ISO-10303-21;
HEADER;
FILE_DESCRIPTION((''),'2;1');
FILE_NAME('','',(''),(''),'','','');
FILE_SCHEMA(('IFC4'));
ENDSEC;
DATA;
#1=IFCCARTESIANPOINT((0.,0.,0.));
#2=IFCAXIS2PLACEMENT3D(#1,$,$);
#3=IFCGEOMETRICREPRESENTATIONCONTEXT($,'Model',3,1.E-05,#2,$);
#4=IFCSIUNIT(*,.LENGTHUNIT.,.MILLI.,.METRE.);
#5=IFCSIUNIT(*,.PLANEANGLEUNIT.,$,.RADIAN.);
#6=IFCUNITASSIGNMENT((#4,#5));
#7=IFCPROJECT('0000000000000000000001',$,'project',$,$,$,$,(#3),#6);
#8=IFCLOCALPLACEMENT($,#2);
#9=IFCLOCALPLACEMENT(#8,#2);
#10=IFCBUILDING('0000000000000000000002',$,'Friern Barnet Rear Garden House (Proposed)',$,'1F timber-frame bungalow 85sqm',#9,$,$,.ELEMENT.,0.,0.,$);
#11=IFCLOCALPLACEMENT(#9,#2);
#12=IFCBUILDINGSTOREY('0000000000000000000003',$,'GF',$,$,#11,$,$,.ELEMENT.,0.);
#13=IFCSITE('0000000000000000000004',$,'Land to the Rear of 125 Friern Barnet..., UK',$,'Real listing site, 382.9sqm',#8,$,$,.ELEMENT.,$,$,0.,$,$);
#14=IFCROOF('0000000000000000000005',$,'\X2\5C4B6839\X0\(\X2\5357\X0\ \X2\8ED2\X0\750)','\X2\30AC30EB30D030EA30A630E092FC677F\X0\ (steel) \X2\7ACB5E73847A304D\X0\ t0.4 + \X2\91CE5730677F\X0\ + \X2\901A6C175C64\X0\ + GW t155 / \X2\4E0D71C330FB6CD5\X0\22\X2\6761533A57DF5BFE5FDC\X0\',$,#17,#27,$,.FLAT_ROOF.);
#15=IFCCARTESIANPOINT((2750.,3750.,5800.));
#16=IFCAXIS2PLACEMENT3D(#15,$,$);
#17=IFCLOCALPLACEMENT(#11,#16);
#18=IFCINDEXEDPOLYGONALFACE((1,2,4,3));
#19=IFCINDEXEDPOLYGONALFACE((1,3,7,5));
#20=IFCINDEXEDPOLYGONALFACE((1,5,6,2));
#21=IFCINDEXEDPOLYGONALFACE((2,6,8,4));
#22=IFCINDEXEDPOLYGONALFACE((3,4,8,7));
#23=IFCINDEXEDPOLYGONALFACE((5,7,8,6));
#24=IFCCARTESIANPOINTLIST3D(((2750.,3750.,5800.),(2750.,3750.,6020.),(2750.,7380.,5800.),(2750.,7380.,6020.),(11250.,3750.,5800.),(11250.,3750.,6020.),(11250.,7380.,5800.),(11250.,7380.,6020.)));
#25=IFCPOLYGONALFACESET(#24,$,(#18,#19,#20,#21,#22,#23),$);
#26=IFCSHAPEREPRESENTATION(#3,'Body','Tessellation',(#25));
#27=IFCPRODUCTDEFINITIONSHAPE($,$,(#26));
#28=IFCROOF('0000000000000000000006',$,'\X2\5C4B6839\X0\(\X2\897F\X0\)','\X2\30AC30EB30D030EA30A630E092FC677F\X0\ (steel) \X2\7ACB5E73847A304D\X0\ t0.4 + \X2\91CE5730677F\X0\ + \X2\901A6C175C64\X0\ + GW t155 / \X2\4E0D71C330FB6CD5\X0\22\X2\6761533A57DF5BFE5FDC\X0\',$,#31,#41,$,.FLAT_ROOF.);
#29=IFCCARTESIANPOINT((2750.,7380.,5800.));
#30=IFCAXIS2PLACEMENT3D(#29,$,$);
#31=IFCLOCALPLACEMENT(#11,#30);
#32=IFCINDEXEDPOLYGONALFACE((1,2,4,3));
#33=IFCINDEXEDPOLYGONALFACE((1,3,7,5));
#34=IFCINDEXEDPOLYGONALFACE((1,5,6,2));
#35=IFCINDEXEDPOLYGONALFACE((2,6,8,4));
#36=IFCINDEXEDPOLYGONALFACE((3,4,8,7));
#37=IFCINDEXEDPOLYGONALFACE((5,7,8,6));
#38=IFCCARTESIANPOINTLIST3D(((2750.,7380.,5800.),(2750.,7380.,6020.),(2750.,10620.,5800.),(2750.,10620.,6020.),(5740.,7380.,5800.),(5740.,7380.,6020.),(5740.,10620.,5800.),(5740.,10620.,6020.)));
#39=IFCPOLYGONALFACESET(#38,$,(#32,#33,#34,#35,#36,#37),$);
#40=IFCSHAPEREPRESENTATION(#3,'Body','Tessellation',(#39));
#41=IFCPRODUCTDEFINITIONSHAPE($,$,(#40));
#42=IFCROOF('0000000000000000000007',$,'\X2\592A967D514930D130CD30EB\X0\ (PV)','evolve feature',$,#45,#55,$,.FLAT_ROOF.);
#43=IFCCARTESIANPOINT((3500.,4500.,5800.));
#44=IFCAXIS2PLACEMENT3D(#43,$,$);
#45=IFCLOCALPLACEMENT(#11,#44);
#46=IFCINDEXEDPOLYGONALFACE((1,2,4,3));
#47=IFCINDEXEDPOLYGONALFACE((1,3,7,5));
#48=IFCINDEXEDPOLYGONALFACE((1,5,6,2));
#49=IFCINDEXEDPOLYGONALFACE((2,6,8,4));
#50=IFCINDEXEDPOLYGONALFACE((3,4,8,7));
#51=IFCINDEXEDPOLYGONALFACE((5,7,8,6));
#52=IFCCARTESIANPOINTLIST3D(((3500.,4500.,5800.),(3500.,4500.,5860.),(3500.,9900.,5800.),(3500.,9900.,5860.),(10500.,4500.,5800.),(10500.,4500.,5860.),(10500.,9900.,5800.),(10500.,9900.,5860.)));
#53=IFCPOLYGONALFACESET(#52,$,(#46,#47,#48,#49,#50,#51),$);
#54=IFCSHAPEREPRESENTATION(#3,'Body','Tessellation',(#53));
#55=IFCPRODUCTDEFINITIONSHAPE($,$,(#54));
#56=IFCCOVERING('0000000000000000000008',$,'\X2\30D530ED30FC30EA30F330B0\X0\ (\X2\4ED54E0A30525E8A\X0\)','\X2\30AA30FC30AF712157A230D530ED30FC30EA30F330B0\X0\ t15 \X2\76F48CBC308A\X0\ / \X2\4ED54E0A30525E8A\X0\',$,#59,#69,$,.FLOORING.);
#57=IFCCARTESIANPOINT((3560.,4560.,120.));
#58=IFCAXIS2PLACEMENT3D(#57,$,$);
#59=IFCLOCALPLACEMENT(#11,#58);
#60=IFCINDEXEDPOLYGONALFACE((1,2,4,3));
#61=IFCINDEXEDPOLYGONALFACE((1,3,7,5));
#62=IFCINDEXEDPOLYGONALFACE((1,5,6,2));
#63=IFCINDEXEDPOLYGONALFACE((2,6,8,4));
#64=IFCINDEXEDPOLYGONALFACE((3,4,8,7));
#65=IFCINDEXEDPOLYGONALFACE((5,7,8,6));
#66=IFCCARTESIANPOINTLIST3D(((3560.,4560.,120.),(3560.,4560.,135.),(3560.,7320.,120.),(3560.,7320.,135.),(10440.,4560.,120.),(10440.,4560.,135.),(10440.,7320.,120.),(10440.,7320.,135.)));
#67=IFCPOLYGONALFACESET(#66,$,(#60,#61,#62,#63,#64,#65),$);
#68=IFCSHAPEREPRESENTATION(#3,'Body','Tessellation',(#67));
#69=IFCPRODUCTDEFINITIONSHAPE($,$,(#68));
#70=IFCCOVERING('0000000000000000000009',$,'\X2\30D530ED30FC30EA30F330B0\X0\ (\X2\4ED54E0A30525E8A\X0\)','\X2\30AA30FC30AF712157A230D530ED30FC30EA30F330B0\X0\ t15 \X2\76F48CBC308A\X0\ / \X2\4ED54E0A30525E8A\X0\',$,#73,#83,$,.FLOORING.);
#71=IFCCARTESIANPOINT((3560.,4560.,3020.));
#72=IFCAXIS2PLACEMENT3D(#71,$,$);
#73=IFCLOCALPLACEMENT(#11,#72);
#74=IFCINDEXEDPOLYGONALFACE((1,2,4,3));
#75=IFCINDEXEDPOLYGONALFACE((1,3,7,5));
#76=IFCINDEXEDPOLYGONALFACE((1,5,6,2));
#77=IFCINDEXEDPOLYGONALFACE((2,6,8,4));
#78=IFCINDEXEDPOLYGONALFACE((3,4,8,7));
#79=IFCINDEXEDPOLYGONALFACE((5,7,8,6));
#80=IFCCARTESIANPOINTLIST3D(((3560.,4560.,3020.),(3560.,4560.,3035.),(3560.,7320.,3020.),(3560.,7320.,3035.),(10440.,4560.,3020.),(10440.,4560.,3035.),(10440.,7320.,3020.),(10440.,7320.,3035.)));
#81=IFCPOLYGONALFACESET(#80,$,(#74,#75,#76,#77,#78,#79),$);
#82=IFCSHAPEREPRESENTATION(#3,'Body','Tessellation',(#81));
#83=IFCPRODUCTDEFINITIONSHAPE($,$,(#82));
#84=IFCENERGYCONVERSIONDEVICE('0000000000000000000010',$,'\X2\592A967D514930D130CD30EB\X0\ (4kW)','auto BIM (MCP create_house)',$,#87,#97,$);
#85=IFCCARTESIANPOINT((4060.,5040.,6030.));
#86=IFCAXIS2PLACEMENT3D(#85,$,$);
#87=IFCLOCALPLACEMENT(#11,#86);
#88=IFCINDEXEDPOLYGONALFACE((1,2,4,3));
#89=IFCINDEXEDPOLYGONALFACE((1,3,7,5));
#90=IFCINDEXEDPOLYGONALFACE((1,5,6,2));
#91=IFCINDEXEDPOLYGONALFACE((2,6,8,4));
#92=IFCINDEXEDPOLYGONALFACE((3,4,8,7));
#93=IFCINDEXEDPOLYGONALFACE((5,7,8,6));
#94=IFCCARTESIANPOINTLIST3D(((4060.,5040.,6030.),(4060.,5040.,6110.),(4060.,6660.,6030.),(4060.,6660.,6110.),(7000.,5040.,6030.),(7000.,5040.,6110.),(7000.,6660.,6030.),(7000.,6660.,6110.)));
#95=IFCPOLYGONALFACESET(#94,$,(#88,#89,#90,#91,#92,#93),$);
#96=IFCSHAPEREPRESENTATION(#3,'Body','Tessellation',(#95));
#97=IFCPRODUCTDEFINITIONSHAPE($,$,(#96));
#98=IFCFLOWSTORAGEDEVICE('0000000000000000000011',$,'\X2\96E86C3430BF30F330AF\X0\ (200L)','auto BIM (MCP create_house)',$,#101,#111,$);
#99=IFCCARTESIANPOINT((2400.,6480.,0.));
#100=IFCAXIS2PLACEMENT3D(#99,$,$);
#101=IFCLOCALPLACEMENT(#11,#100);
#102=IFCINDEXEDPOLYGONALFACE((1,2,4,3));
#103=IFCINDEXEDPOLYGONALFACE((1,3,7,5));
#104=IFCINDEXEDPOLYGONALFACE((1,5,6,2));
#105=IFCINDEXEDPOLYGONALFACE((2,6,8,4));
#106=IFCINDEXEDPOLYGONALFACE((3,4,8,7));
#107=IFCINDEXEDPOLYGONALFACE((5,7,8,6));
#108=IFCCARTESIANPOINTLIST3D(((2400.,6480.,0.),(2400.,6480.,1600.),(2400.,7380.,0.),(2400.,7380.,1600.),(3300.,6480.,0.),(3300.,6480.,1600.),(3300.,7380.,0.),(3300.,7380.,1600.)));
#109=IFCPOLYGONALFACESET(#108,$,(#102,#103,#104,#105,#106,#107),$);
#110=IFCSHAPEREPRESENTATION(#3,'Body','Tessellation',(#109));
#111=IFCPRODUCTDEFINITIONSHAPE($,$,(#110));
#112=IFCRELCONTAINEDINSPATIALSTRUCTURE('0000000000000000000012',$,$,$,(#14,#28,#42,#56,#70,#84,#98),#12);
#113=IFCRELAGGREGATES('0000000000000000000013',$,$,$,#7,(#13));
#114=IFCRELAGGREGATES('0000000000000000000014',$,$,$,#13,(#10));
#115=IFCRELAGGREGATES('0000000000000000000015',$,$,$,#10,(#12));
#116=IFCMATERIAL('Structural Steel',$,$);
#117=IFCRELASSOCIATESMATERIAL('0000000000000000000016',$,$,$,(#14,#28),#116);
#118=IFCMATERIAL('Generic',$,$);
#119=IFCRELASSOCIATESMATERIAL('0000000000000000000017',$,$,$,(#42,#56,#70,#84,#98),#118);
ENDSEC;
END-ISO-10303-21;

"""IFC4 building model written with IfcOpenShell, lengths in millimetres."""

from ifc_helpers import new_model, si_unit, frame, frame_2d, origin, place, context, project, spatial, rectangle, extrude, material, element, save


model = new_model("IFC4")

# Units and contexts
model_context = context("Model", 3, precision=1e-05, world=origin())
ifc_project = project(units=[si_unit("LENGTHUNIT", "METRE", prefix="MILLI"), si_unit("PLANEANGLEUNIT", "RADIAN")], contexts=[model_context])

# Site, building, storey
site_placement = place(None, origin())
site = spatial("IfcSite", under=ifc_project, at=site_placement, Name="Land to the Rear of 125 Friern Barnet..., UK", ObjectType="Real listing site, 382.9sqm", CompositionType="ELEMENT", RefElevation=0.0)
building_placement = place(site_placement, origin())
building = spatial("IfcBuilding", under=site, at=building_placement, Name="Friern Barnet Rear Garden House (Proposed)", ObjectType="1F timber-frame bungalow 85sqm", CompositionType="ELEMENT", ElevationOfRefHeight=0.0, ElevationOfTerrain=0.0)
storey_placement = place(building_placement, origin())
storey = spatial("IfcBuildingStorey", under=building, at=storey_placement, Name="GF", CompositionType="ELEMENT", Elevation=0.0)

# Shared definitions
ifc_material_1 = material(Name="Generic")

# Roofs
ifc_material_2 = material(Name="Structural Steel")
roof_1_placement = place(storey_placement, frame((2750.0, 3750.0, 5800.0)))
element("IfcRoof", 1, at=roof_1_placement, inside=storey, material=ifc_material_2, Name="屋根(南 軒750)", Description="ガルバリウム鋼板 (steel) 立平葺き t0.4 + 野地板 + 通気層 + GW t155 / 不燃・法22条区域対応", PredefinedType="FLAT_ROOF", context=model_context, shape_type="SweptSolid", body=[
    extrude(rectangle(XDim=8500.0, YDim=3630.0, at=frame_2d((4250.0, 1815.0))), frame((2750.0, 3750.0, 5800.0)), (0.0, 0.0, 1.0), 220.0),
])
roof_2_placement = place(storey_placement, frame((2750.0, 7380.0, 5800.0)))
element("IfcRoof", 2, at=roof_2_placement, inside=storey, material=ifc_material_2, Name="屋根(西)", Description="ガルバリウム鋼板 (steel) 立平葺き t0.4 + 野地板 + 通気層 + GW t155 / 不燃・法22条区域対応", PredefinedType="FLAT_ROOF", context=model_context, shape_type="SweptSolid", body=[
    extrude(rectangle(XDim=2990.0, YDim=3240.0, at=frame_2d((1495.0, 1620.0))), frame((2750.0, 7380.0, 5800.0)), (0.0, 0.0, 1.0), 220.0),
])
roof_3_placement = place(storey_placement, frame((3500.0, 4500.0, 5800.0)))
element("IfcRoof", 3, at=roof_3_placement, inside=storey, material=ifc_material_1, Name="太陽光パネル (PV)", Description="evolve feature", PredefinedType="FLAT_ROOF", context=model_context, shape_type="SweptSolid", body=[
    extrude(rectangle(XDim=7000.0, YDim=5400.0, at=frame_2d((3500.0, 2700.0))), frame((3500.0, 4500.0, 5800.0)), (0.0, 0.0, 1.0), 60.0),
])

# Coverings
covering_1_placement = place(storey_placement, frame((3560.0, 4560.0, 120.0)))
element("IfcCovering", 4, at=covering_1_placement, inside=storey, material=ifc_material_1, Name="フローリング (仕上げ床)", Description="オーク無垢フローリング t15 直貼り / 仕上げ床", PredefinedType="FLOORING", context=model_context, shape_type="SweptSolid", body=[
    extrude(rectangle(XDim=6880.0, YDim=2760.0, at=frame_2d((3440.0, 1380.0))), frame((3560.0, 4560.0, 120.0)), (0.0, 0.0, 1.0), 15.0),
])
covering_2_placement = place(storey_placement, frame((3560.0, 4560.0, 3020.0)))
element("IfcCovering", 5, at=covering_2_placement, inside=storey, material=ifc_material_1, Name="フローリング (仕上げ床)", Description="オーク無垢フローリング t15 直貼り / 仕上げ床", PredefinedType="FLOORING", context=model_context, shape_type="SweptSolid", body=[
    extrude(rectangle(XDim=6880.0, YDim=2760.0, at=frame_2d((3440.0, 1380.0))), frame((3560.0, 4560.0, 3020.0)), (0.0, 0.0, 1.0), 15.0),
])

# Energy conversion device
energy_conversion_device_placement = place(storey_placement, frame((4060.0, 5040.0, 6030.0)))
element("IfcEnergyConversionDevice", 6, at=energy_conversion_device_placement, inside=storey, material=ifc_material_1, Name="太陽光パネル (4kW)", Description="auto BIM (MCP create_house)", context=model_context, shape_type="SweptSolid", body=[
    extrude(rectangle(XDim=2940.0, YDim=1620.0, at=frame_2d((1470.0, 810.0))), frame((4060.0, 5040.0, 6030.0)), (0.0, 0.0, 1.0), 80.0),
])

# Flow storage device
flow_storage_device_placement = place(storey_placement, frame((2400.0, 6480.0, 0.0)))
element("IfcFlowStorageDevice", 7, at=flow_storage_device_placement, inside=storey, material=ifc_material_1, Name="雨水タンク (200L)", Description="auto BIM (MCP create_house)", context=model_context, shape_type="SweptSolid", body=[
    extrude(rectangle(XDim=900.0, YDim=900.0, at=frame_2d((450.0, 450.0))), frame((2400.0, 6480.0, 0.0)), (0.0, 0.0, 1.0), 1600.0),
])

save(model, "model.ifc")
